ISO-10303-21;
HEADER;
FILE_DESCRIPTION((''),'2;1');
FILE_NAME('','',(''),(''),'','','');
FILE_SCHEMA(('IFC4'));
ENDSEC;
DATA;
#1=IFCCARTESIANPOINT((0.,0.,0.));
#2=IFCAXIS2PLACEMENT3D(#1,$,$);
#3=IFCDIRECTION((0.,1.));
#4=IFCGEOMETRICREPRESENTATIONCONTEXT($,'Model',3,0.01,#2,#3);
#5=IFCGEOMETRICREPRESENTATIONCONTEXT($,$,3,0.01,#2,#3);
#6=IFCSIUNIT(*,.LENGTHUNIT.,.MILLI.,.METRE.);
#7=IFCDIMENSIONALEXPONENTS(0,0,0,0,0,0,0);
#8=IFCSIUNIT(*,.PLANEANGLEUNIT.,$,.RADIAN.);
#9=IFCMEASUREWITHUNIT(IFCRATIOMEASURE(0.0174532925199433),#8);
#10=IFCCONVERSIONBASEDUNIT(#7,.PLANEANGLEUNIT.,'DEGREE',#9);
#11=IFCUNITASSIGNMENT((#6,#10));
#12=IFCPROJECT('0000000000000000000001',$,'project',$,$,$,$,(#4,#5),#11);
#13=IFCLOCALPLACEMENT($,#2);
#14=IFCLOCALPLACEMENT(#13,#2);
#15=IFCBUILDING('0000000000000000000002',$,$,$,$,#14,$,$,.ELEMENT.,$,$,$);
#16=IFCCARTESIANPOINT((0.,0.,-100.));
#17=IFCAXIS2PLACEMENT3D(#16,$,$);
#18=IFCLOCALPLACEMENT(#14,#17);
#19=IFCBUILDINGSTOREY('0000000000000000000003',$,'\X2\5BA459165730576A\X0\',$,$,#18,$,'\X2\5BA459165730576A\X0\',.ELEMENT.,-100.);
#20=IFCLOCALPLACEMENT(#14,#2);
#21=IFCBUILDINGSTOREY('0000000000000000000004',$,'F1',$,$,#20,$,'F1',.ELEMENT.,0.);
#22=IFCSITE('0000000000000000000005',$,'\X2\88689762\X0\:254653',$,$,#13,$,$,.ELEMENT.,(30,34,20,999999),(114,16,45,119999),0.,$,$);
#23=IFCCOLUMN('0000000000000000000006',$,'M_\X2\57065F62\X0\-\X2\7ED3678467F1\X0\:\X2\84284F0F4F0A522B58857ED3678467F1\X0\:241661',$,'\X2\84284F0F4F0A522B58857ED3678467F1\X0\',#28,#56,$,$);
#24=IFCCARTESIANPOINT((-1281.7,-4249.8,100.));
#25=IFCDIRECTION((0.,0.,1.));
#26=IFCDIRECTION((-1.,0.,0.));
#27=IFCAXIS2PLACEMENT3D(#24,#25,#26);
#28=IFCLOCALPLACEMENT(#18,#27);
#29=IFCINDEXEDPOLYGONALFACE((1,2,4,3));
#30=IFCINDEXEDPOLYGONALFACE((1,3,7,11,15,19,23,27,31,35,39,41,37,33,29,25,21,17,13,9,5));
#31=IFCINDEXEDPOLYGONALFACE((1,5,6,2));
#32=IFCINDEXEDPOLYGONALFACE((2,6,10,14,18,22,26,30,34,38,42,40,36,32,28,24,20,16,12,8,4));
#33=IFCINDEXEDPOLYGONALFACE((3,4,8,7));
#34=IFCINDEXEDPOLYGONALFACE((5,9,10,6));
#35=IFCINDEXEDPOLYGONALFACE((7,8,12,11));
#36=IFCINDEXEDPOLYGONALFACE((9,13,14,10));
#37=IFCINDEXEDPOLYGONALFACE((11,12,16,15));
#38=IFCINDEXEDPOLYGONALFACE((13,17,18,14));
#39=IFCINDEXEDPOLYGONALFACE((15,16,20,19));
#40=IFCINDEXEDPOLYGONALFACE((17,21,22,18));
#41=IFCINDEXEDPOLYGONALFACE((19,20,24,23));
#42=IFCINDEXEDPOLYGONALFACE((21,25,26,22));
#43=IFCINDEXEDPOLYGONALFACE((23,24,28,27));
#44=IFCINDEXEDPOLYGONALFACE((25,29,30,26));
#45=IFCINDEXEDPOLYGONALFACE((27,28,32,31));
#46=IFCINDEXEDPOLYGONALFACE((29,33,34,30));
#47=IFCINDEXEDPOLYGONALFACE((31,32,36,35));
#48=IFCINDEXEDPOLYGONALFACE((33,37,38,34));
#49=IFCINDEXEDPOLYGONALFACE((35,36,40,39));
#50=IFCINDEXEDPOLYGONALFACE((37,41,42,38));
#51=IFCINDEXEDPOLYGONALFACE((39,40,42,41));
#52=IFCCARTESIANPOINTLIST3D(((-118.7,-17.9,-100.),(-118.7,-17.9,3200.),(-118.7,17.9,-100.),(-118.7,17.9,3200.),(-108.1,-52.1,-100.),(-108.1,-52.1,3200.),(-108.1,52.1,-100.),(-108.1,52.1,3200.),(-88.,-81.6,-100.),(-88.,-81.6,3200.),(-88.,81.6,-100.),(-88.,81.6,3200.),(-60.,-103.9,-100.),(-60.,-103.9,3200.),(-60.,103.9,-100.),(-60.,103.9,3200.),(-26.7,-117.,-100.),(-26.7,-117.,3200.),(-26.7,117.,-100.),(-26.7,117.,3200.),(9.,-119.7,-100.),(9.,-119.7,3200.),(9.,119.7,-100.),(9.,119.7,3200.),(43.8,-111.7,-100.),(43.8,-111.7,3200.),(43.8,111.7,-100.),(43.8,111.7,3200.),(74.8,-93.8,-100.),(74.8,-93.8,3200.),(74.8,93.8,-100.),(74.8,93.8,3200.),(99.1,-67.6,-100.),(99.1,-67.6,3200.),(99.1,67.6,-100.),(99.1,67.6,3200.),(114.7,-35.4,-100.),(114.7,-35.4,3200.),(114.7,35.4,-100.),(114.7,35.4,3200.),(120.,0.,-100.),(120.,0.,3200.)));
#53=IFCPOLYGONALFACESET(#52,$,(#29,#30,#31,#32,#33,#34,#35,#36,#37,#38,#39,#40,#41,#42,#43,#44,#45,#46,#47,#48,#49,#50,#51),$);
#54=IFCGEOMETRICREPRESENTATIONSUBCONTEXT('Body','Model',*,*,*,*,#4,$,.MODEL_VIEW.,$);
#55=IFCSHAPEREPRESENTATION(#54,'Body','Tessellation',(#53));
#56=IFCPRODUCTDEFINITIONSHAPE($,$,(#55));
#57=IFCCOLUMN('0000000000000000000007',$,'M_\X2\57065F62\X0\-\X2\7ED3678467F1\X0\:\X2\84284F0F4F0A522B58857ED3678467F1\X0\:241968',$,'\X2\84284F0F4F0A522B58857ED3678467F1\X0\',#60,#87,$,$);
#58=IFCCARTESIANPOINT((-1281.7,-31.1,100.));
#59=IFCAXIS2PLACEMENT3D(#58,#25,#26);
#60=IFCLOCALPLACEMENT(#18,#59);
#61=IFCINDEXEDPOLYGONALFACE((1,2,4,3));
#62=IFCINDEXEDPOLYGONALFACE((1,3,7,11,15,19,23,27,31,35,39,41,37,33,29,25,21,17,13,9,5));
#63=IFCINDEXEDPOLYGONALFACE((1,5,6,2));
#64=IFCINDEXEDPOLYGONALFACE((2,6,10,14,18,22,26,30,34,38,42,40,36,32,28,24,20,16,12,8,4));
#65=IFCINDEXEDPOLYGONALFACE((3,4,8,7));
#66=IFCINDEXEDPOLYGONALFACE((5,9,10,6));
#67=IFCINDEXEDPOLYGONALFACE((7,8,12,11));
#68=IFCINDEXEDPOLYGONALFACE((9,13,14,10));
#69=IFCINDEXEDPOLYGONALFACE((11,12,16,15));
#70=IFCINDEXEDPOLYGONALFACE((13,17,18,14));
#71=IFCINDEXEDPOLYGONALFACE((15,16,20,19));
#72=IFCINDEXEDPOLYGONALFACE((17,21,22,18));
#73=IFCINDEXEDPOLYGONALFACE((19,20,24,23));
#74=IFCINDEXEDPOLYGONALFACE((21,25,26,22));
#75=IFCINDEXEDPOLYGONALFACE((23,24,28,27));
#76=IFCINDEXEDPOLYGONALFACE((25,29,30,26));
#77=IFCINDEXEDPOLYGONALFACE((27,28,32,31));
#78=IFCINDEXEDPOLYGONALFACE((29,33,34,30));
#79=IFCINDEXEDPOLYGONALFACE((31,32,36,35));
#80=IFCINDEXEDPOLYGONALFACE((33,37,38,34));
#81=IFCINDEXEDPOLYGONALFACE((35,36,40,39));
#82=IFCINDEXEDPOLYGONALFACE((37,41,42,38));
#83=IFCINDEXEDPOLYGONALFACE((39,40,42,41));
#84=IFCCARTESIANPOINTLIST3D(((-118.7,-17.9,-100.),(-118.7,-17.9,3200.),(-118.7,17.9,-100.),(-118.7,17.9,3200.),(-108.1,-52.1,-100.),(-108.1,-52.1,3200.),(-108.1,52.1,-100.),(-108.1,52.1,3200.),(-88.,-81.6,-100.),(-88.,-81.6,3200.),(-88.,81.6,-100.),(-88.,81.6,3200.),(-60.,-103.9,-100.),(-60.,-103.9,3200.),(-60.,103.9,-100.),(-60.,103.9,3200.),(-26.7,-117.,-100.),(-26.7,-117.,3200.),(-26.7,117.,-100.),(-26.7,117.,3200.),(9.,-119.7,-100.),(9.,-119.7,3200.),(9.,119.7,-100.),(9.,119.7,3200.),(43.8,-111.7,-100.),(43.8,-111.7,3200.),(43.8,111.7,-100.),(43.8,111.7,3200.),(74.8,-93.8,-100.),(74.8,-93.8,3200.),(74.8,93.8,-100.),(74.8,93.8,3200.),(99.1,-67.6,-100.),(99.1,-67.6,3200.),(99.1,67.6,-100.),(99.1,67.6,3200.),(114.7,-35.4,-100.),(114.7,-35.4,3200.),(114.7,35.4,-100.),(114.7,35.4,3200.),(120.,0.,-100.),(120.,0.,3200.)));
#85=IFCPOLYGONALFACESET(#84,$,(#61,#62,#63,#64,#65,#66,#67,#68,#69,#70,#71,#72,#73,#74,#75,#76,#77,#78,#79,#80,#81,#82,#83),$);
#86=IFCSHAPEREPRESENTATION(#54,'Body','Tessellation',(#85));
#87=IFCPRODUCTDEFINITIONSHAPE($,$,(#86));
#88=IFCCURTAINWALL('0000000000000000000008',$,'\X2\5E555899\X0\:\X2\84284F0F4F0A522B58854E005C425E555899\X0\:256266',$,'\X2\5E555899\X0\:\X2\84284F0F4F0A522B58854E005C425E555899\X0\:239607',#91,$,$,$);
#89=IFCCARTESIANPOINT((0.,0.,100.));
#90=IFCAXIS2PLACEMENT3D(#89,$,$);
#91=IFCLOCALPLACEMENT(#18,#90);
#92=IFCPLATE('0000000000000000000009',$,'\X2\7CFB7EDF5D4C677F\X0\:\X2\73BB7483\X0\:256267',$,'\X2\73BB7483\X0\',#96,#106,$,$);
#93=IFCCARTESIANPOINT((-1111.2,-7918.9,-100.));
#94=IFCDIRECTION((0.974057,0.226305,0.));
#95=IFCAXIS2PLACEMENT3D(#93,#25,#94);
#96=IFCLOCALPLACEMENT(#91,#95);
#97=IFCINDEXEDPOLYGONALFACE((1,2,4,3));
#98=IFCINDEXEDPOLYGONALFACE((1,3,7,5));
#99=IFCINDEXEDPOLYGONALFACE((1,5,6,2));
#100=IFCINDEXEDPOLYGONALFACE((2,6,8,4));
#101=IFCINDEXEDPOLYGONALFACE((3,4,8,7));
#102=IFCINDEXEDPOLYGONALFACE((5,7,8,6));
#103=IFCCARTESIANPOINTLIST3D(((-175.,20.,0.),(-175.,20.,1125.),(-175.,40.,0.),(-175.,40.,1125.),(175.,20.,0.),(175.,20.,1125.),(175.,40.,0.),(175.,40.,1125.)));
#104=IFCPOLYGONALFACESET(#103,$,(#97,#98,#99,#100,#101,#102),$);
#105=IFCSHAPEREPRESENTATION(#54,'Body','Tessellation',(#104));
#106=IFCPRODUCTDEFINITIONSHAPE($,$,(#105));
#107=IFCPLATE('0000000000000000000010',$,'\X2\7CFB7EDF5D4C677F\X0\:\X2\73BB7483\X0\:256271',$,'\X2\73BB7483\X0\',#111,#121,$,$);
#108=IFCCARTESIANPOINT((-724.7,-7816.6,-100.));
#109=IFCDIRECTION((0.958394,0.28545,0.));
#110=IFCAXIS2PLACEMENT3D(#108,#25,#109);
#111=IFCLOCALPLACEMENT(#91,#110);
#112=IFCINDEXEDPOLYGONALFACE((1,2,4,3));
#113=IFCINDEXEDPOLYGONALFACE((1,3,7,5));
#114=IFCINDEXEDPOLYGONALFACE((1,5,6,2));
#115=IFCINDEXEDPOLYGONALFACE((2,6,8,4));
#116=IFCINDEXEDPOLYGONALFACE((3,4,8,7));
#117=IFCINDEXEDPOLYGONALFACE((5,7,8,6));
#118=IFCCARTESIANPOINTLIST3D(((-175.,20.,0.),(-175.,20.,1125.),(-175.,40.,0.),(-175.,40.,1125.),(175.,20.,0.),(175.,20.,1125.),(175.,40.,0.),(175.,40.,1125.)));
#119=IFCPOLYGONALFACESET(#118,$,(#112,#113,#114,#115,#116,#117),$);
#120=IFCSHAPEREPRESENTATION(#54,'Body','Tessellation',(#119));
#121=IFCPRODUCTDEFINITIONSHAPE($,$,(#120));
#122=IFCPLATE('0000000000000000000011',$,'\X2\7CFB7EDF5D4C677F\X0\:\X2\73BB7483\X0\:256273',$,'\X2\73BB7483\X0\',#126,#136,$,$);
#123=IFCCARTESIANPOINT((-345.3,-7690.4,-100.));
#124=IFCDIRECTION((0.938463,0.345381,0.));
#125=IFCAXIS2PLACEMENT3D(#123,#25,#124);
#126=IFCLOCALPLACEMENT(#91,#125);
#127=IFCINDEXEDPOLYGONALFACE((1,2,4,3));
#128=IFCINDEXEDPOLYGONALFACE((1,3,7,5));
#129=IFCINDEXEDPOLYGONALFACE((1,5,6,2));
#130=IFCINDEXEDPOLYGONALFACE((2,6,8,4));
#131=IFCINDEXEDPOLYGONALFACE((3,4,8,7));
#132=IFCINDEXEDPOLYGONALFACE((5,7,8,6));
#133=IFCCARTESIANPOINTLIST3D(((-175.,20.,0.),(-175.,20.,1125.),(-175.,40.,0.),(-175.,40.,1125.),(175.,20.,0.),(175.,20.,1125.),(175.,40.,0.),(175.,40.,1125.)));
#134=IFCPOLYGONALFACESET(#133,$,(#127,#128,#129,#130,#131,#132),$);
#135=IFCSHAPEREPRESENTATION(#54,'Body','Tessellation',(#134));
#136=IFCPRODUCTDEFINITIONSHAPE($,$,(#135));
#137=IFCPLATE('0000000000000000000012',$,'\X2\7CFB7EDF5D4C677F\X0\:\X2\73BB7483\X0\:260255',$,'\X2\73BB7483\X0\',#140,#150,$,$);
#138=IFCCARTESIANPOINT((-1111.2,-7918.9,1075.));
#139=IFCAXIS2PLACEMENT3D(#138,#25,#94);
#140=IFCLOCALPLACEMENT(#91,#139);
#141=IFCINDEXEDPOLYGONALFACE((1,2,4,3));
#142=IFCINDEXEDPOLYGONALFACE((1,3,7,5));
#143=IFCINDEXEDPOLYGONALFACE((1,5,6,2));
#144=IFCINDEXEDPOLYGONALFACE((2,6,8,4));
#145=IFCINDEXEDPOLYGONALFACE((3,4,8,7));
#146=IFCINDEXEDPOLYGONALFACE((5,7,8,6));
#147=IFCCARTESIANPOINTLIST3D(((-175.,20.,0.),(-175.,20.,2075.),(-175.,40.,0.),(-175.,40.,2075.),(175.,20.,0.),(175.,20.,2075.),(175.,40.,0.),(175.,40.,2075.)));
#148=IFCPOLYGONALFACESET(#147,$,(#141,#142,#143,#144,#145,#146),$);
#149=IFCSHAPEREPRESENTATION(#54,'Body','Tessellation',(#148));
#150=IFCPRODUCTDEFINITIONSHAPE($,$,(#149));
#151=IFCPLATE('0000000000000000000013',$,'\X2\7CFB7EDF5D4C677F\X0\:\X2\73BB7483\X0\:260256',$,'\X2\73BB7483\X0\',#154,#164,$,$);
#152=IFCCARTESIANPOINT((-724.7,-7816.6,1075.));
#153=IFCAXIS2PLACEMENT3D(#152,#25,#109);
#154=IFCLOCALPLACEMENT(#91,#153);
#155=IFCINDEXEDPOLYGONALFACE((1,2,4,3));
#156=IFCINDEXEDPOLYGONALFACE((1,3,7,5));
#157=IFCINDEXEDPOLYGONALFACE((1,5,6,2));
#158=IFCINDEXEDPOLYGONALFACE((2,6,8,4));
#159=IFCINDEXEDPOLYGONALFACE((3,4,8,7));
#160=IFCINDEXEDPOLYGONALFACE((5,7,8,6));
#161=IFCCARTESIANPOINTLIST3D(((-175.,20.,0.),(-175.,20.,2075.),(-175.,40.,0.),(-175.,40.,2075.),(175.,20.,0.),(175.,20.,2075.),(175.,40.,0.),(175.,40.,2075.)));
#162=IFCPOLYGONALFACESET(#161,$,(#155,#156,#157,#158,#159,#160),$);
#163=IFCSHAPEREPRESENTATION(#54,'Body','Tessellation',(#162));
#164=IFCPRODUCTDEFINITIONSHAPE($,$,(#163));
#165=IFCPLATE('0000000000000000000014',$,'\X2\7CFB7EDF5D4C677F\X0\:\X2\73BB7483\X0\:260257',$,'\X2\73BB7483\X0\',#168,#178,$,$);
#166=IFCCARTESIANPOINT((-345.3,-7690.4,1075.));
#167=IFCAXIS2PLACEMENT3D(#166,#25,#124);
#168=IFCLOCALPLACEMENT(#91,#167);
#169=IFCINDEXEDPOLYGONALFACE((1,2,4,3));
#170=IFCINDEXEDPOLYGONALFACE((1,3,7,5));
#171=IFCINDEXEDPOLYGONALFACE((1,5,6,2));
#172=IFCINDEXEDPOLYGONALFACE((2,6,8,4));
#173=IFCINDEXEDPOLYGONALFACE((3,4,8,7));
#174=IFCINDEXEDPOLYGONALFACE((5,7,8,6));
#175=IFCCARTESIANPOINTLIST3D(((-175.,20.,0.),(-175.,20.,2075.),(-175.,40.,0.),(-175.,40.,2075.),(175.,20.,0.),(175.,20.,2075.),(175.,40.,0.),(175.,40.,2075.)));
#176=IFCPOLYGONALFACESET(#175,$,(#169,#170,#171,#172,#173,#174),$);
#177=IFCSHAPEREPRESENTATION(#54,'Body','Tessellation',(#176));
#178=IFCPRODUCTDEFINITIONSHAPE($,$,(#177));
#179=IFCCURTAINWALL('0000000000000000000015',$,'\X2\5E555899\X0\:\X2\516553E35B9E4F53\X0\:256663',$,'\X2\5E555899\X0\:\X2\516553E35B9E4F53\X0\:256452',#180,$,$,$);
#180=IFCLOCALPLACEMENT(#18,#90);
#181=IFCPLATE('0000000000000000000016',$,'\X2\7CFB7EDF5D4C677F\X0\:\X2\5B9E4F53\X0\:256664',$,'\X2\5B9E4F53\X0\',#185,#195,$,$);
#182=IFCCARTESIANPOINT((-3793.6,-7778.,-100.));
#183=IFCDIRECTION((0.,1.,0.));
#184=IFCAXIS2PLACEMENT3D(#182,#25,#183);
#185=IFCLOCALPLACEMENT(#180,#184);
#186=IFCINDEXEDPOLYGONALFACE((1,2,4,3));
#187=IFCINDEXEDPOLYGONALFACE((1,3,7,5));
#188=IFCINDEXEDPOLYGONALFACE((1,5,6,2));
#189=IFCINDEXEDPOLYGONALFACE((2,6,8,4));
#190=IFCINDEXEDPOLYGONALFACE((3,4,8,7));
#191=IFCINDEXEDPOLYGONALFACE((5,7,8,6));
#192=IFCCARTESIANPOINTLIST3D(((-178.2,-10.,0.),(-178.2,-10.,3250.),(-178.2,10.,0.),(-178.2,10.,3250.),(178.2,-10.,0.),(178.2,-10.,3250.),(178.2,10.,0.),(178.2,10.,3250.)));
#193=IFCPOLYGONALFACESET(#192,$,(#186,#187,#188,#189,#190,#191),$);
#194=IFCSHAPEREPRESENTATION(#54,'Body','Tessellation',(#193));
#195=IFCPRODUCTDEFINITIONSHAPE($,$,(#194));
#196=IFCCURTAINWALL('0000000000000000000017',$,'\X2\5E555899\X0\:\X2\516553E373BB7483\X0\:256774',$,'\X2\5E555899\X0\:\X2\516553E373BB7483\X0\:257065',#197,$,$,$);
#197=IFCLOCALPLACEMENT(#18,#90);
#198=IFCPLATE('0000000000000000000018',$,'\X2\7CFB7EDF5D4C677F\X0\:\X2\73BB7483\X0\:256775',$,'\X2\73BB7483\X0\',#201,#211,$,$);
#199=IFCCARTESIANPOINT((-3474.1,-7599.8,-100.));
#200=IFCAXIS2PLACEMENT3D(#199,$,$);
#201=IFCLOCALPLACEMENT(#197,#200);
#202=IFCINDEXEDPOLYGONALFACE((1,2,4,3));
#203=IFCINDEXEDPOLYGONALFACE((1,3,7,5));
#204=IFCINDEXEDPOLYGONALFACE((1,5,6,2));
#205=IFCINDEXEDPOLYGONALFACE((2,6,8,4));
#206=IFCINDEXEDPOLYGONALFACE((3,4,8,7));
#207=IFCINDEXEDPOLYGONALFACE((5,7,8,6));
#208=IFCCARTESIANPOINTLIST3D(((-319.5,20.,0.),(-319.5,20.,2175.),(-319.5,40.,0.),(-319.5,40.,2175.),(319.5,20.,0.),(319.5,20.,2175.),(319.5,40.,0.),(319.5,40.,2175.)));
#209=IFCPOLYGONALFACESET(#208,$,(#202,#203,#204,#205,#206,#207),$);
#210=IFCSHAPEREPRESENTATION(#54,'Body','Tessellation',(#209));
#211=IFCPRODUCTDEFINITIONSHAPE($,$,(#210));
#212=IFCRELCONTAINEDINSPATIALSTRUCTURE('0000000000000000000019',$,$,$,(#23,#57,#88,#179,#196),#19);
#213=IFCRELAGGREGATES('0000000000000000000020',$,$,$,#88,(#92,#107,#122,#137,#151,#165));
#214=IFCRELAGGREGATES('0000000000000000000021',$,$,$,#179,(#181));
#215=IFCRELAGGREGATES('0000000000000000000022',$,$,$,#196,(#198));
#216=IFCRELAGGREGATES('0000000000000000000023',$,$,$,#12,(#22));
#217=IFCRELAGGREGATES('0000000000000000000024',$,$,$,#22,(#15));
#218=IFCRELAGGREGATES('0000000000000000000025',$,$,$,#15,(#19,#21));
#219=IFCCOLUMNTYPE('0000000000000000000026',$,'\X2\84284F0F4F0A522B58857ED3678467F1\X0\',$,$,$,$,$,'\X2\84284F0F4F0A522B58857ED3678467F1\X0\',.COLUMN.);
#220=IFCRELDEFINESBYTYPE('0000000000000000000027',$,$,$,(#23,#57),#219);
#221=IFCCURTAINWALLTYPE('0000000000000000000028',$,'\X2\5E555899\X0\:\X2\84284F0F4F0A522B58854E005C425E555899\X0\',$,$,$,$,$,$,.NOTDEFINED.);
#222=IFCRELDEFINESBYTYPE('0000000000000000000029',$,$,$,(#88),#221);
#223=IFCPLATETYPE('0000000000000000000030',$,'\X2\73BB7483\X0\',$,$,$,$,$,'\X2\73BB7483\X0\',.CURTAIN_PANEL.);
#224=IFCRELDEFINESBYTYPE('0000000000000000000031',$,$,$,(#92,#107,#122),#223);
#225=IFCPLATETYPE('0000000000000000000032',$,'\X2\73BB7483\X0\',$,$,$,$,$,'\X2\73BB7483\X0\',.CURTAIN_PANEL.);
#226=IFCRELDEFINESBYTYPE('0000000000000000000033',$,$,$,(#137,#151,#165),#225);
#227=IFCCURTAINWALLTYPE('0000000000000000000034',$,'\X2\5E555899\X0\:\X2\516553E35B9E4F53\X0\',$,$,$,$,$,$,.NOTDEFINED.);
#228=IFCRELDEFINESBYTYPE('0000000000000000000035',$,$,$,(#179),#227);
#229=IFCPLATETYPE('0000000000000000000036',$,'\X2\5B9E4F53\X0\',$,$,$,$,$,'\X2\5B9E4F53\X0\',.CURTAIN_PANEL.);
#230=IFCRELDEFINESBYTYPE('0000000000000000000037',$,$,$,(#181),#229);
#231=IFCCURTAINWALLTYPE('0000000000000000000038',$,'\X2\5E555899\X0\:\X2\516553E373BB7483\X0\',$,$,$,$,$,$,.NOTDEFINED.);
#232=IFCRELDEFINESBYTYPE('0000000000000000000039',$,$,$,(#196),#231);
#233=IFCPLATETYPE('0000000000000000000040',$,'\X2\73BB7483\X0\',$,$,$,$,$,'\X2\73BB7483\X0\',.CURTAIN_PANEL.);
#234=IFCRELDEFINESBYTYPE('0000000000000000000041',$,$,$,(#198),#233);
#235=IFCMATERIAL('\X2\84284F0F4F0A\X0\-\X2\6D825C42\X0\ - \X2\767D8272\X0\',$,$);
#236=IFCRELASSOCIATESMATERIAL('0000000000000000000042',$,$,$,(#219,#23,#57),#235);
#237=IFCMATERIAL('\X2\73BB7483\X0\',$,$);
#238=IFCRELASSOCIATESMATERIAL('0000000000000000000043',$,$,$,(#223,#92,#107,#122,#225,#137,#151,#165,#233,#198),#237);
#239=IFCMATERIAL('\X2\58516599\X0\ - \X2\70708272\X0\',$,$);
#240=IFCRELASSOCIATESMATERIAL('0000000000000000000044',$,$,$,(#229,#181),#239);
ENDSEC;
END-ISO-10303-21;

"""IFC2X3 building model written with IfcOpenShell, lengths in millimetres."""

from ifc_helpers import new_model, entity, si_unit, converted_unit, direction, frame, frame_2d, origin, origin_2d_with_axis, place, context, subcontext, project, spatial, rectangle, circle, extrude, source, transform, mapped, material, type_object, type_shapes, element, aggregate, save


model = new_model("IFC2X3")

# Units and contexts
model_context = context("Model", 3, precision=0.01, world=origin(), true_north=direction((0.0, 1.0)))
context_of_model = context(None, 3, precision=0.01, world=origin(), true_north=direction((0.0, 1.0)))
body_context = subcontext(model_context, "Body", "Model", "MODEL_VIEW")
ifc_project = project(units=[si_unit("LENGTHUNIT", "METRE", prefix="MILLI"), converted_unit("PLANEANGLEUNIT", "DEGREE", entity("IfcRatioMeasure", 0.0174532925199433), si_unit("PLANEANGLEUNIT", "RADIAN"), dimensions=[0, 0, 0, 0, 0, 0, 0])], contexts=[model_context, context_of_model])

# Site, building, storey
site_placement = place(None, origin())
site = spatial("IfcSite", under=ifc_project, at=site_placement, Name="表面:254653", CompositionType="ELEMENT", RefLatitude=(30, 34, 20, 999999), RefLongitude=(114, 16, 45, 119999), RefElevation=0.0)
building_placement = place(site_placement, origin())
building = spatial("IfcBuilding", under=site, at=building_placement, CompositionType="ELEMENT")
storey_1_placement = place(building_placement, frame((0.0, 0.0, -100.0)))
storey_1 = spatial("IfcBuildingStorey", under=building, at=storey_1_placement, Name="室外地坪", LongName="室外地坪", CompositionType="ELEMENT", Elevation=-100.0)

# Columns
ifc_material_1 = material(Name="萨伏伊-涂层 - 白色")
column_type_1 = type_object("IfcColumnType", Name="萨伏伊别墅结构柱", ElementType="萨伏伊别墅结构柱", PredefinedType="COLUMN", material=ifc_material_1)
shared_shape_1 = source(origin(), body_context, "Body", "SweptSolid", [
    extrude(circle(Radius=120.0, at=frame_2d((0.0, 0.0), x_axis=(1.0, 0.0))), frame((0.0, 0.0, -100.0)), (0.0, 0.0, 1.0), 3300.0),
])
type_shapes(column_type_1, [shared_shape_1])
for number, where, z_axis, x_axis, name in (
    (1, (-1281.7, -4249.8, 100.0), (0.0, 0.0, 1.0), (-1.0, 0.0, 0.0), "M_圆形-结构柱:萨伏伊别墅结构柱:241661"),
    (2, (-1281.7, -31.1, 100.0), (0.0, 0.0, 1.0), (-1.0, 0.0, 0.0), "M_圆形-结构柱:萨伏伊别墅结构柱:241968"),
):
    element("IfcColumn", number, at=place(storey_1_placement, frame(where, z_axis=z_axis, x_axis=x_axis)), inside=storey_1, type_object=column_type_1, material=ifc_material_1, Name=name, ObjectType="萨伏伊别墅结构柱", context=body_context, shape_type="MappedRepresentation", body=[
        mapped(shared_shape_1, transform((0.0, 0.0, 0.0), scale=1.0)),
    ])

# Curtain wall, plates
curtain_wall_type_1 = type_object("IfcCurtainWallType", Name="幕墙:萨伏伊别墅一层幕墙", PredefinedType="NOTDEFINED")
curtain_wall_1_placement = place(storey_1_placement, frame((0.0, 0.0, 100.0)))
curtain_wall_1 = element("IfcCurtainWall", 3, at=curtain_wall_1_placement, inside=storey_1, type_object=curtain_wall_type_1, Name="幕墙:萨伏伊别墅一层幕墙:256266", ObjectType="幕墙:萨伏伊别墅一层幕墙:239607")
ifc_material_2 = material(Name="玻璃")
plate_type_1 = type_object("IfcPlateType", Name="玻璃", ElementType="玻璃", PredefinedType="CURTAIN_PANEL", material=ifc_material_2)
shared_shape_2 = source(origin(), body_context, "Body", "SweptSolid", [
    extrude(rectangle(XDim=20.0, YDim=350.0, at=frame_2d((0.0, 0.0), x_axis=(1.0, 0.0))), frame((0.0, 30.0, 0.0), z_axis=(0.0, 0.0, 1.0), x_axis=(0.0, 1.0, 0.0)), (0.0, 0.0, 1.0), 1125.0),
])
type_shapes(plate_type_1, [shared_shape_2])
plate_1_placement = place(curtain_wall_1_placement, frame((-1111.2, -7918.9, -100.0), z_axis=(0.0, 0.0, 1.0), x_axis=(0.974057, 0.226305, 0.0)))
plate_1 = element("IfcPlate", 4, at=plate_1_placement, type_object=plate_type_1, material=ifc_material_2, Name="系统嵌板:玻璃:256267", ObjectType="玻璃", context=body_context, shape_type="MappedRepresentation", body=[
    mapped(shared_shape_2, transform((0.0, 0.0, 0.0), scale=1.0)),
])
plate_2_placement = place(curtain_wall_1_placement, frame((-724.7, -7816.6, -100.0), z_axis=(0.0, 0.0, 1.0), x_axis=(0.958394, 0.28545, 0.0)))
plate_2 = element("IfcPlate", 5, at=plate_2_placement, type_object=plate_type_1, material=ifc_material_2, Name="系统嵌板:玻璃:256271", ObjectType="玻璃", context=body_context, shape_type="MappedRepresentation", body=[
    mapped(shared_shape_2, transform((0.0, 0.0, 0.0), scale=1.0)),
])
plate_3_placement = place(curtain_wall_1_placement, frame((-345.3, -7690.4, -100.0), z_axis=(0.0, 0.0, 1.0), x_axis=(0.938463, 0.345381, 0.0)))
plate_3 = element("IfcPlate", 6, at=plate_3_placement, type_object=plate_type_1, material=ifc_material_2, Name="系统嵌板:玻璃:256273", ObjectType="玻璃", context=body_context, shape_type="MappedRepresentation", body=[
    mapped(shared_shape_2, transform((0.0, 0.0, 0.0), scale=1.0)),
])
plate_type_2 = type_object("IfcPlateType", Name="玻璃", ElementType="玻璃", PredefinedType="CURTAIN_PANEL", material=ifc_material_2)
shared_shape_3 = source(origin(), body_context, "Body", "SweptSolid", [
    extrude(rectangle(XDim=20.0, YDim=350.0, at=frame_2d((0.0, 0.0), x_axis=(1.0, 0.0))), frame((0.0, 30.0, 0.0), z_axis=(0.0, 0.0, 1.0), x_axis=(0.0, 1.0, 0.0)), (0.0, 0.0, 1.0), 2075.0),
])
type_shapes(plate_type_2, [shared_shape_3])
plate_4_placement = place(curtain_wall_1_placement, frame((-1111.2, -7918.9, 1075.0), z_axis=(0.0, 0.0, 1.0), x_axis=(0.974057, 0.226305, 0.0)))
plate_4 = element("IfcPlate", 7, at=plate_4_placement, type_object=plate_type_2, material=ifc_material_2, Name="系统嵌板:玻璃:260255", ObjectType="玻璃", context=body_context, shape_type="MappedRepresentation", body=[
    mapped(shared_shape_3, transform((0.0, 0.0, 0.0), scale=1.0)),
])
plate_5_placement = place(curtain_wall_1_placement, frame((-724.7, -7816.6, 1075.0), z_axis=(0.0, 0.0, 1.0), x_axis=(0.958394, 0.28545, 0.0)))
plate_5 = element("IfcPlate", 8, at=plate_5_placement, type_object=plate_type_2, material=ifc_material_2, Name="系统嵌板:玻璃:260256", ObjectType="玻璃", context=body_context, shape_type="MappedRepresentation", body=[
    mapped(shared_shape_3, transform((0.0, 0.0, 0.0), scale=1.0)),
])
plate_6_placement = place(curtain_wall_1_placement, frame((-345.3, -7690.4, 1075.0), z_axis=(0.0, 0.0, 1.0), x_axis=(0.938463, 0.345381, 0.0)))
plate_6 = element("IfcPlate", 9, at=plate_6_placement, type_object=plate_type_2, material=ifc_material_2, Name="系统嵌板:玻璃:260257", ObjectType="玻璃", context=body_context, shape_type="MappedRepresentation", body=[
    mapped(shared_shape_3, transform((0.0, 0.0, 0.0), scale=1.0)),
])
aggregate(curtain_wall_1, [plate_1, plate_2, plate_3, plate_4, plate_5, plate_6])

# Curtain wall, plate
curtain_wall_type_2 = type_object("IfcCurtainWallType", Name="幕墙:入口实体", PredefinedType="NOTDEFINED")
curtain_wall_2_placement = place(storey_1_placement, frame((0.0, 0.0, 100.0)))
curtain_wall_2 = element("IfcCurtainWall", 10, at=curtain_wall_2_placement, inside=storey_1, type_object=curtain_wall_type_2, Name="幕墙:入口实体:256663", ObjectType="幕墙:入口实体:256452")
ifc_material_3 = material(Name="塑料 - 灰色")
plate_type_3 = type_object("IfcPlateType", Name="实体", ElementType="实体", PredefinedType="CURTAIN_PANEL", material=ifc_material_3)
shared_shape_4 = source(origin(), body_context, "Body", "SweptSolid", [
    extrude(rectangle(XDim=20.0, YDim=356.3, at=origin_2d_with_axis()), frame((0.0, 0.0, 0.0), z_axis=(0.0, 0.0, 1.0), x_axis=(0.0, 1.0, 0.0)), (0.0, 0.0, 1.0), 3250.0),
])
type_shapes(plate_type_3, [shared_shape_4])
plate_7_placement = place(curtain_wall_2_placement, frame((-3793.6, -7778.0, -100.0), z_axis=(0.0, 0.0, 1.0), x_axis=(0.0, 1.0, 0.0)))
plate_7 = element("IfcPlate", 11, at=plate_7_placement, type_object=plate_type_3, material=ifc_material_3, Name="系统嵌板:实体:256664", ObjectType="实体", context=body_context, shape_type="MappedRepresentation", body=[
    mapped(shared_shape_4, transform((0.0, 0.0, 0.0), scale=1.0)),
])
aggregate(curtain_wall_2, [plate_7])

# Curtain wall, plate
curtain_wall_type_3 = type_object("IfcCurtainWallType", Name="幕墙:入口玻璃", PredefinedType="NOTDEFINED")
curtain_wall_3_placement = place(storey_1_placement, frame((0.0, 0.0, 100.0)))
curtain_wall_3 = element("IfcCurtainWall", 12, at=curtain_wall_3_placement, inside=storey_1, type_object=curtain_wall_type_3, Name="幕墙:入口玻璃:256774", ObjectType="幕墙:入口玻璃:257065")
plate_type_4 = type_object("IfcPlateType", Name="玻璃", ElementType="玻璃", PredefinedType="CURTAIN_PANEL", material=ifc_material_2)
shared_shape_5 = source(origin(), body_context, "Body", "SweptSolid", [
    extrude(rectangle(XDim=20.0, YDim=639.0, at=frame_2d((0.0, 0.0), x_axis=(1.0, 0.0))), frame((0.0, 30.0, 0.0), z_axis=(0.0, 0.0, 1.0), x_axis=(0.0, 1.0, 0.0)), (0.0, 0.0, 1.0), 2175.0),
])
type_shapes(plate_type_4, [shared_shape_5])
plate_8_placement = place(curtain_wall_3_placement, frame((-3474.1, -7599.8, -100.0)))
plate_8 = element("IfcPlate", 13, at=plate_8_placement, type_object=plate_type_4, material=ifc_material_2, Name="系统嵌板:玻璃:256775", ObjectType="玻璃", context=body_context, shape_type="MappedRepresentation", body=[
    mapped(shared_shape_5, transform((0.0, 0.0, 0.0), scale=1.0)),
])

# Shared definitions
storey_2_placement = place(building_placement, origin())
storey_2 = spatial("IfcBuildingStorey", under=building, at=storey_2_placement, Name="F1", LongName="F1", CompositionType="ELEMENT", Elevation=0.0)

aggregate(curtain_wall_3, [plate_8])

save(model, "model.ifc")
